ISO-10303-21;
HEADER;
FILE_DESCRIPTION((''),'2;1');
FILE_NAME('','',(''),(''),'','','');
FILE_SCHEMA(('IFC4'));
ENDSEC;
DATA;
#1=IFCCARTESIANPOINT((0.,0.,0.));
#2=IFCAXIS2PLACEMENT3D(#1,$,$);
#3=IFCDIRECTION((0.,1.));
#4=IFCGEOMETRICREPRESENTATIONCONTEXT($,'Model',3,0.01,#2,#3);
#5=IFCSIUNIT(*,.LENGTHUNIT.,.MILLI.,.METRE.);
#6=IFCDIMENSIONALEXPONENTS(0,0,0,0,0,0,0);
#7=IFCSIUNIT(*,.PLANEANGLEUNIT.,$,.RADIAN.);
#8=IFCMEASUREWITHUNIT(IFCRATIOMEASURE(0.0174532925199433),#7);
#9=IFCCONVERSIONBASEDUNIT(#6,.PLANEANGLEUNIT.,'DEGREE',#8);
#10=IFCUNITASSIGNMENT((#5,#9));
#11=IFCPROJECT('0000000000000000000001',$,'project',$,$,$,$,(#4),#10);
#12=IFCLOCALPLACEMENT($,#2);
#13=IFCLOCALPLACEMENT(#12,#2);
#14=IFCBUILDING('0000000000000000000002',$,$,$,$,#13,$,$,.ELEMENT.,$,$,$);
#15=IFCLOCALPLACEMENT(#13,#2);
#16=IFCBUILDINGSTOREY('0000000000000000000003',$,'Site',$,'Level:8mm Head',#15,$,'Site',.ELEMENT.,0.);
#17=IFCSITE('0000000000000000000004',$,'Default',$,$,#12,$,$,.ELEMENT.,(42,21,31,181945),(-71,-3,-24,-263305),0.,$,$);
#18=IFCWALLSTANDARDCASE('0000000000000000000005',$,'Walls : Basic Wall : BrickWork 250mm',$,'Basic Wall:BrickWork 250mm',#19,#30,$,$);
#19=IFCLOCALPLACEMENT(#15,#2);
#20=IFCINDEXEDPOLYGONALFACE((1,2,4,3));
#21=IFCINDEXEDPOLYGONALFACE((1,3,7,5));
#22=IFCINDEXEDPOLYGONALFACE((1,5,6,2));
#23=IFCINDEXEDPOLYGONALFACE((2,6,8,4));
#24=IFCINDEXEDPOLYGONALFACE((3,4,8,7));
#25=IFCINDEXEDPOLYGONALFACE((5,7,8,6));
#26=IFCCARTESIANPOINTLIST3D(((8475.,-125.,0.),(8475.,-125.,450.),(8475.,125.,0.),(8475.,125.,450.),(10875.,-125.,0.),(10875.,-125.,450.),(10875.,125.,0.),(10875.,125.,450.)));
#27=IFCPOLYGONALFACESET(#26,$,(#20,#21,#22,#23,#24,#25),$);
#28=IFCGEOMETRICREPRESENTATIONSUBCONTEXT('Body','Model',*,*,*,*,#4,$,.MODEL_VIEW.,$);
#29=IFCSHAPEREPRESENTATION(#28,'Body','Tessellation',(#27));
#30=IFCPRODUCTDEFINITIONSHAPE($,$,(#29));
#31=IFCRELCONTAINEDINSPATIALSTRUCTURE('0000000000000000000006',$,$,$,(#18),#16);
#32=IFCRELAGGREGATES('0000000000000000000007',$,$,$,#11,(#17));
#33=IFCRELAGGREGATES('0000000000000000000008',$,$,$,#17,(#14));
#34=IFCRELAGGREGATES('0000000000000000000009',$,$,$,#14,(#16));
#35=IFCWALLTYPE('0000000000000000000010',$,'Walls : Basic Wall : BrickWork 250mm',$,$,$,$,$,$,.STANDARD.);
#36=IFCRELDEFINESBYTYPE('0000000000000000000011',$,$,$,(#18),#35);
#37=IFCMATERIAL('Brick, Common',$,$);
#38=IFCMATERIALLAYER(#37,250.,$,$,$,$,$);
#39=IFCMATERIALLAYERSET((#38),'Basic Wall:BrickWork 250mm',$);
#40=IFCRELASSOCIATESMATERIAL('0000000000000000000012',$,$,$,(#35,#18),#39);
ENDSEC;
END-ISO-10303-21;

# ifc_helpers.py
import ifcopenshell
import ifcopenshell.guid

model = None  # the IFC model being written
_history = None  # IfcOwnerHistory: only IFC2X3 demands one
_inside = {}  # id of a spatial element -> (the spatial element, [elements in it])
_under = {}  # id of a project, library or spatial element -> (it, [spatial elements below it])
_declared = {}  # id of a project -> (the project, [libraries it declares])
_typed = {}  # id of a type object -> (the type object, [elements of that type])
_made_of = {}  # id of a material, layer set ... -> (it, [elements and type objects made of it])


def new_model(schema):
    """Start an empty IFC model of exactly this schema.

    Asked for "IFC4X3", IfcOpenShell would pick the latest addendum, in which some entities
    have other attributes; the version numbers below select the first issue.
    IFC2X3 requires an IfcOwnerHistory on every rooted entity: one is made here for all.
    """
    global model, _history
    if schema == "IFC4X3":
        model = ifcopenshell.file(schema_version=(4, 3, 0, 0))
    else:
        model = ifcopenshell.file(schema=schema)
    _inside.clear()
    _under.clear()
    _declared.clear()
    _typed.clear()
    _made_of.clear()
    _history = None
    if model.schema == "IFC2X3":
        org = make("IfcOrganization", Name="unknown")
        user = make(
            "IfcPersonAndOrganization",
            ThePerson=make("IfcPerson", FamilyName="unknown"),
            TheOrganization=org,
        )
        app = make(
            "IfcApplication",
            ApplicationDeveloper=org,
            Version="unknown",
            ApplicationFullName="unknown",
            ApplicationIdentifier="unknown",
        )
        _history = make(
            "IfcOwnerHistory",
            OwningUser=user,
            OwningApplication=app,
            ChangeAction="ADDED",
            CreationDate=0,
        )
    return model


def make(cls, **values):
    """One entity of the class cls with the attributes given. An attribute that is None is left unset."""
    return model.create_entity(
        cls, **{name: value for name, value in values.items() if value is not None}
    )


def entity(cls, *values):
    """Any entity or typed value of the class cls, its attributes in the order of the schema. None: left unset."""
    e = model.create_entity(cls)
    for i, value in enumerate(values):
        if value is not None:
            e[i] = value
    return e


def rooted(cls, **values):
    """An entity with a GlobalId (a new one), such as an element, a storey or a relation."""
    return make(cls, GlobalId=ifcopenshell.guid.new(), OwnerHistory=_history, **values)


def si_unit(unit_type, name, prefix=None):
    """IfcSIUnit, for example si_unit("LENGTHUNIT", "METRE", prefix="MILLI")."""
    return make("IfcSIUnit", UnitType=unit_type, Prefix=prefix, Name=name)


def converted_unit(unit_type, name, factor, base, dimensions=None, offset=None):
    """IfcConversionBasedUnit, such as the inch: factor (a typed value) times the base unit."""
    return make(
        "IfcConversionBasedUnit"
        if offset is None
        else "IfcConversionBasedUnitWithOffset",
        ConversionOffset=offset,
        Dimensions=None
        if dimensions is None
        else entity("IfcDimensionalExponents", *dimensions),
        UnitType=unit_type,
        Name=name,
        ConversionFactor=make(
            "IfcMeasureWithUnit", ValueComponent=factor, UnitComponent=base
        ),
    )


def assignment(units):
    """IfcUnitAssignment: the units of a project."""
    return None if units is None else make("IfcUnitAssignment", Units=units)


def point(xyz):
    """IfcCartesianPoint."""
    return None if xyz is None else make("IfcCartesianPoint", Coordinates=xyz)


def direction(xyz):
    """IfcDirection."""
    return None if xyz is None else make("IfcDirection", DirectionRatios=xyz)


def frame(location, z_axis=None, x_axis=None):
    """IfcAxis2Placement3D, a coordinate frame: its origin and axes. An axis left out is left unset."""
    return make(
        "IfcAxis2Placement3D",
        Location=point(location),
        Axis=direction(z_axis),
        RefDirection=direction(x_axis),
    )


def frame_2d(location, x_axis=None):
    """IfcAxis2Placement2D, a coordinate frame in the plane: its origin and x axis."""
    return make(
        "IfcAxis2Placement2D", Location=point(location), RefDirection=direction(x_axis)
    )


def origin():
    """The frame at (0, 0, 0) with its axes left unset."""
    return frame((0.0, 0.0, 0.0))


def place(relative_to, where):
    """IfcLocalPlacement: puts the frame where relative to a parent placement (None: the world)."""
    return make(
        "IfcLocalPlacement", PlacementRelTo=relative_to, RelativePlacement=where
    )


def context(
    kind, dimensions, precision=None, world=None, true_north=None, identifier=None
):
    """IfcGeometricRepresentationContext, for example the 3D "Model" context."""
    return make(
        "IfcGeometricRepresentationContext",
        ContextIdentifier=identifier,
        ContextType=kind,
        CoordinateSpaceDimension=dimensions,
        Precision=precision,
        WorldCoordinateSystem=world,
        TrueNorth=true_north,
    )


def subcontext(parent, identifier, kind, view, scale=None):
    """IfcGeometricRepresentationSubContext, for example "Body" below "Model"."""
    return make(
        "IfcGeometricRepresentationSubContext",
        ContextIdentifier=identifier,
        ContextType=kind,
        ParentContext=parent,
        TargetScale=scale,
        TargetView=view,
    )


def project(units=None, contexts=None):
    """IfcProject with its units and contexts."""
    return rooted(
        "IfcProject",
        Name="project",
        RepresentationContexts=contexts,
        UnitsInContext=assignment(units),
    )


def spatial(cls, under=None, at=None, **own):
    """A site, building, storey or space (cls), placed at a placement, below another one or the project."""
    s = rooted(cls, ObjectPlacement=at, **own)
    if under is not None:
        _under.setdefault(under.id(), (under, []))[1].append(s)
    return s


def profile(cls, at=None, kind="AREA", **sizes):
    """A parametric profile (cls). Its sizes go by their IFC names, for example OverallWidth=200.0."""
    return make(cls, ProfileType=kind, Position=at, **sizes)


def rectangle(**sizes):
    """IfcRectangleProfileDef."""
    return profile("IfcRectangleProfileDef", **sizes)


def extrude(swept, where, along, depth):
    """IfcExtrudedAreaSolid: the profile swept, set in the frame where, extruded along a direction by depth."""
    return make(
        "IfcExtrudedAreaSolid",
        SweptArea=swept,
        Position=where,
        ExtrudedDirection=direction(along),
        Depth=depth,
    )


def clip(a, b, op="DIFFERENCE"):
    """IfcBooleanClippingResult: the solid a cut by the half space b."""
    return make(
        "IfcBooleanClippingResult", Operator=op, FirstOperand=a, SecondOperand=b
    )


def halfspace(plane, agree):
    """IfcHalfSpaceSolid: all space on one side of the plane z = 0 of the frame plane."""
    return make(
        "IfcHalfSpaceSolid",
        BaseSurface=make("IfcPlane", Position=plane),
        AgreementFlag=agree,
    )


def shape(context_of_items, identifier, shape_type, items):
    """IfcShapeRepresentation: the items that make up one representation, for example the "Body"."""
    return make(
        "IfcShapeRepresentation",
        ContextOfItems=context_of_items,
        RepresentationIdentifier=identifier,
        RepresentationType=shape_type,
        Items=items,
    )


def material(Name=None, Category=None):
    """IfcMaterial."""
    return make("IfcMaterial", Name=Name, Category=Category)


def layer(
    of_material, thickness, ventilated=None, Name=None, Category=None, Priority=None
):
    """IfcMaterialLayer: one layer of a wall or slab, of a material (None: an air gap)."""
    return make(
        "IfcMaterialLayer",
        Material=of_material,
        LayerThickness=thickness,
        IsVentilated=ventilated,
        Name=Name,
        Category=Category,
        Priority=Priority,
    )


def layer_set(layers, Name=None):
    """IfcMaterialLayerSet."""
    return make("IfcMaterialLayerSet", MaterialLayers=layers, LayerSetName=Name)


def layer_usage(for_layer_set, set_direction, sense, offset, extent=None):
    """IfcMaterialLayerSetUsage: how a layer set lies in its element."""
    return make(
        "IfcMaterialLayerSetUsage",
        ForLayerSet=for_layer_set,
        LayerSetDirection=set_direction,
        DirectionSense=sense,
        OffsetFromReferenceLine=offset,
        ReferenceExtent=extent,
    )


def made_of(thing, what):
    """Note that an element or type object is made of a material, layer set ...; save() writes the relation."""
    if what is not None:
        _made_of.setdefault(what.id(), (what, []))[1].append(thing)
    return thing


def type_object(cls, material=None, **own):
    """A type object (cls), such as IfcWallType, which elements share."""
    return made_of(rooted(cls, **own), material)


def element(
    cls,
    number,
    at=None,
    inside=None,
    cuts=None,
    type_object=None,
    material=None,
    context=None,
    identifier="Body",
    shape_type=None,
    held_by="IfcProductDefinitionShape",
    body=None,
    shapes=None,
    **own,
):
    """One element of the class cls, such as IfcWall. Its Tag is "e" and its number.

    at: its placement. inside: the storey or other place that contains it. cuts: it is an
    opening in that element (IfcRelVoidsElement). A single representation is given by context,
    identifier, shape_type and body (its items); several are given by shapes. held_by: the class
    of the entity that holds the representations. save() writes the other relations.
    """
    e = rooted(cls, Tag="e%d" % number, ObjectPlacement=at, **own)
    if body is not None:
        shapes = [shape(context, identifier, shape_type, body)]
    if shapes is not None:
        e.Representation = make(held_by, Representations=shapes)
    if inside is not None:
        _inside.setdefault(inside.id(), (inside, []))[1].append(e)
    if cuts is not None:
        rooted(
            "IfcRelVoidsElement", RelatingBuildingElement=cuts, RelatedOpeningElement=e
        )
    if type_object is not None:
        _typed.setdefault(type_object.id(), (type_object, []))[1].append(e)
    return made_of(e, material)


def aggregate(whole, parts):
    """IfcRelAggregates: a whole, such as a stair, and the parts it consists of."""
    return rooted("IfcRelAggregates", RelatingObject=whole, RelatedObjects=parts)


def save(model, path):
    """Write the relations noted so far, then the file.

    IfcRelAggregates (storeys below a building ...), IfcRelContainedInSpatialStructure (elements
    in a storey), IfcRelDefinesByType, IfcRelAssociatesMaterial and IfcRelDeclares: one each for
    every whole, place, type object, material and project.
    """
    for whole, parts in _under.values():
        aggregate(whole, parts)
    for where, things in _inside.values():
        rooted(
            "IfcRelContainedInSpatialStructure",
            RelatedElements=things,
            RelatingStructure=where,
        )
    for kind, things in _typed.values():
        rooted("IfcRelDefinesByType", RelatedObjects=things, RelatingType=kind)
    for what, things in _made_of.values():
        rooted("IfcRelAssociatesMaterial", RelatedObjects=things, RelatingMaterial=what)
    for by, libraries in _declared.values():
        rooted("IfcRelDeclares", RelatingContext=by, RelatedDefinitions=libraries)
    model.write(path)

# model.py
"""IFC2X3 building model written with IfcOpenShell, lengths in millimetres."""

from ifc_helpers import new_model, entity, si_unit, converted_unit, direction, frame, frame_2d, origin, place, context, subcontext, project, spatial, rectangle, extrude, clip, halfspace, material, layer, layer_set, layer_usage, type_object, element, save


model = new_model("IFC2X3")

# Units and contexts
model_context = context("Model", 3, precision=0.01, world=origin(), true_north=direction((0.0, 1.0)))
body_context = subcontext(model_context, "Body", "Model", "MODEL_VIEW")
ifc_project = project(units=[si_unit("LENGTHUNIT", "METRE", prefix="MILLI"), converted_unit("PLANEANGLEUNIT", "DEGREE", entity("IfcRatioMeasure", 0.0174532925199433), si_unit("PLANEANGLEUNIT", "RADIAN"), dimensions=[0, 0, 0, 0, 0, 0, 0])], contexts=[model_context])

# Site, building, storey
site_placement = place(None, origin())
site = spatial("IfcSite", under=ifc_project, at=site_placement, Name="Default", CompositionType="ELEMENT", RefLatitude=(42, 21, 31, 181945), RefLongitude=(-71, -3, -24, -263305), RefElevation=0.0)
building_placement = place(site_placement, origin())
building = spatial("IfcBuilding", under=site, at=building_placement, CompositionType="ELEMENT")
storey_placement = place(building_placement, origin())
storey = spatial("IfcBuildingStorey", under=building, at=storey_placement, Name="Site", ObjectType="Level:8mm Head", LongName="Site", CompositionType="ELEMENT", Elevation=0.0)

# Wall
ifc_material = material(Name="Brick, Common")
ifc_layer = layer(ifc_material, 250.0)
ifc_layer_set = layer_set([ifc_layer], Name="Basic Wall:BrickWork 250mm")
ifc_layer_usage = layer_usage(ifc_layer_set, "AXIS2", "NEGATIVE", 125.0)
wall_type = type_object("IfcWallType", Name="Walls : Basic Wall : BrickWork 250mm", PredefinedType="STANDARD", material=ifc_layer_set)
wall_placement = place(storey_placement, frame((8475.0, 0.0, 0.0)))
element("IfcWallStandardCase", 1, at=wall_placement, inside=storey, type_object=wall_type, material=ifc_layer_usage, Name="Walls : Basic Wall : BrickWork 250mm", ObjectType="Basic Wall:BrickWork 250mm", context=body_context, shape_type="Clipping", body=[
    clip(extrude(rectangle(XDim=2400.0, YDim=250.0, at=frame_2d((1200.0, 0.0), x_axis=(-1.0, 0.0))), origin(), (0.0, 0.0, 1.0), 450.0), halfspace(origin(), True)),
])

save(model, "model.ifc")
